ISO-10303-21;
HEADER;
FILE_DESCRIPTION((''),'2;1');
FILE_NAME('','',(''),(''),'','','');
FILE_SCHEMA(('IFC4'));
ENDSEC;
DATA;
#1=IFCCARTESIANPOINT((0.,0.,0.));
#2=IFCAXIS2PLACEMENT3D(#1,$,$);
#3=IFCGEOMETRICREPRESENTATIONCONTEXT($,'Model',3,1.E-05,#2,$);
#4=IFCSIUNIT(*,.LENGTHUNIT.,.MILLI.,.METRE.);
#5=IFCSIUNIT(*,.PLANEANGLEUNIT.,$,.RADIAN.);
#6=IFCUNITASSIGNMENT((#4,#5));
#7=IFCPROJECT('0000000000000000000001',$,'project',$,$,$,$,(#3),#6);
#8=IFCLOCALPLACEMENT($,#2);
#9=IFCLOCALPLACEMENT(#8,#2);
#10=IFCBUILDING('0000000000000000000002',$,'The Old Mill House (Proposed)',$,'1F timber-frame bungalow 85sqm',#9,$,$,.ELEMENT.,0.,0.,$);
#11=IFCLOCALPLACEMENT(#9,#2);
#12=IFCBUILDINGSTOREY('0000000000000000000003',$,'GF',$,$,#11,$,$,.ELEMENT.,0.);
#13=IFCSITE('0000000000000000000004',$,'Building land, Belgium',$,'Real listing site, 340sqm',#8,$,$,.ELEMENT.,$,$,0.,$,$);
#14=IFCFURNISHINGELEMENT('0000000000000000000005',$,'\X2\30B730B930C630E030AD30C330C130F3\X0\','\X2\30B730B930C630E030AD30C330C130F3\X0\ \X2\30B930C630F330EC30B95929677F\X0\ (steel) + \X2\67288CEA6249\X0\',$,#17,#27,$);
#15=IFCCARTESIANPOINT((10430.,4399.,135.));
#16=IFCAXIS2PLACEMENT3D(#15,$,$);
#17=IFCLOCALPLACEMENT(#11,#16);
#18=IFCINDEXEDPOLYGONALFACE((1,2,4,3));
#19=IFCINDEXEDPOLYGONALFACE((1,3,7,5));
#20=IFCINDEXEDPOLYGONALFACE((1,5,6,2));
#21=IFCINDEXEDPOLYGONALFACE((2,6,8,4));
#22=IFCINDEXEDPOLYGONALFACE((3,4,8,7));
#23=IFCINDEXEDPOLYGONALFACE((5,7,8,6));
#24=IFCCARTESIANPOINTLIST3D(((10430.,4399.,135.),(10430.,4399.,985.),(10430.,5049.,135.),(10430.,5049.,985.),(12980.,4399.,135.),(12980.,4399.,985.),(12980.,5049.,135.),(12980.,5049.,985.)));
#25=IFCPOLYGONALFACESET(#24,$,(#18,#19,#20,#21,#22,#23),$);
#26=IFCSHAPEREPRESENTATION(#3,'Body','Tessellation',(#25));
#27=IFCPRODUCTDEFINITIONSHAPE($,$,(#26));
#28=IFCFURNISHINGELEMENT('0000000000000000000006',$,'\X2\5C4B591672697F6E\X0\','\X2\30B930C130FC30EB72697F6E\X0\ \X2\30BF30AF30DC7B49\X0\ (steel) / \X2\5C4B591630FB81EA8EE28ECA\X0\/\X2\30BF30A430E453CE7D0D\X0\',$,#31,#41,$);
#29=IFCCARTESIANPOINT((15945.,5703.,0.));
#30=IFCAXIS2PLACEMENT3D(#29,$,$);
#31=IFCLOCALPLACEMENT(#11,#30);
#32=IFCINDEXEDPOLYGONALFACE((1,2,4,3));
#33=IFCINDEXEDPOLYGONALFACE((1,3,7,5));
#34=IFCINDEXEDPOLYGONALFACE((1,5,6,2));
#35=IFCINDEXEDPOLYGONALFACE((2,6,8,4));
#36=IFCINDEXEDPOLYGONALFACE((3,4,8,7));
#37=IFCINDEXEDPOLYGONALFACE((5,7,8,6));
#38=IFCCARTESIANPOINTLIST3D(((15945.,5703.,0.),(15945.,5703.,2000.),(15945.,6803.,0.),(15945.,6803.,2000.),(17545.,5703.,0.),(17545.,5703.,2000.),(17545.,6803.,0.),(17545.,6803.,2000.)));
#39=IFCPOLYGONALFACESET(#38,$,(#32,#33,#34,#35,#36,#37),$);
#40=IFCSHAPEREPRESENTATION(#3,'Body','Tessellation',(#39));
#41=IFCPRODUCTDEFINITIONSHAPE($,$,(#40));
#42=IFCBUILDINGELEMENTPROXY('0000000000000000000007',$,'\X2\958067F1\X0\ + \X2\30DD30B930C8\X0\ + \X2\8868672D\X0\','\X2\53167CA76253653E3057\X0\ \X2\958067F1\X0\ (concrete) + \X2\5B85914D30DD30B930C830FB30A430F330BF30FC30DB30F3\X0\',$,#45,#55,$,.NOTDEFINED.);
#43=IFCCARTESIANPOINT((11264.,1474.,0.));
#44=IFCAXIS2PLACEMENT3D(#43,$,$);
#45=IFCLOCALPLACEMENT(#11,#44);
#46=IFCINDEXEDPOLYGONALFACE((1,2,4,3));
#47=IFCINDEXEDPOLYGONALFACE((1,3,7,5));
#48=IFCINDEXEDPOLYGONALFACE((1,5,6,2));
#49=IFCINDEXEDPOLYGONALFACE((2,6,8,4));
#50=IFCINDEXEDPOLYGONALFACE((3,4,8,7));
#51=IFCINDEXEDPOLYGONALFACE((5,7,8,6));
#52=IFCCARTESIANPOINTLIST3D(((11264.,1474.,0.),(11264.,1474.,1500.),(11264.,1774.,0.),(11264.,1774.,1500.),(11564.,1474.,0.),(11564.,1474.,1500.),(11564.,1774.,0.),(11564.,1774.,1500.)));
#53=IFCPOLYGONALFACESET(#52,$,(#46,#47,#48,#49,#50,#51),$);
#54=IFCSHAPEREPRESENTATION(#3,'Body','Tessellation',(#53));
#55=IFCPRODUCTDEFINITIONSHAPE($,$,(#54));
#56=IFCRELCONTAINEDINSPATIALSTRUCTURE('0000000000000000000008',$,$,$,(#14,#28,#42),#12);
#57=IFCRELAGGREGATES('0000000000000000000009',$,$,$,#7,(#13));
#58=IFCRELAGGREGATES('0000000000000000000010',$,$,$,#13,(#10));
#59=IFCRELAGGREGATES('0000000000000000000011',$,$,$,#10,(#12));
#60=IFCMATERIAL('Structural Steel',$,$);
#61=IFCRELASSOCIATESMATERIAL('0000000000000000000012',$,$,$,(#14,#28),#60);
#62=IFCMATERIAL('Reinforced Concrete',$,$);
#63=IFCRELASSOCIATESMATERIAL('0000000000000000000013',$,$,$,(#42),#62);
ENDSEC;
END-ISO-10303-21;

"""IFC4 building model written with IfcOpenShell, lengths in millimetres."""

from ifc_helpers import new_model, si_unit, frame, frame_2d, origin, place, context, project, spatial, rectangle, extrude, material, element, save


model = new_model("IFC4")

# Units and contexts
model_context = context("Model", 3, precision=1e-05, world=origin())
ifc_project = project(units=[si_unit("LENGTHUNIT", "METRE", prefix="MILLI"), si_unit("PLANEANGLEUNIT", "RADIAN")], contexts=[model_context])

# Site, building, storey
site_placement = place(None, origin())
site = spatial("IfcSite", under=ifc_project, at=site_placement, Name="Building land, Belgium", ObjectType="Real listing site, 340sqm", CompositionType="ELEMENT", RefElevation=0.0)
building_placement = place(site_placement, origin())
building = spatial("IfcBuilding", under=site, at=building_placement, Name="The Old Mill House (Proposed)", ObjectType="1F timber-frame bungalow 85sqm", CompositionType="ELEMENT", ElevationOfRefHeight=0.0, ElevationOfTerrain=0.0)
storey_placement = place(building_placement, origin())
storey = spatial("IfcBuildingStorey", under=building, at=storey_placement, Name="GF", CompositionType="ELEMENT", Elevation=0.0)

# Shared definitions
ifc_material_1 = material(Name="Reinforced Concrete")

# Shared definitions
ifc_material_2 = material(Name="Structural Steel")

# Furnishing elements
furnishing_1_placement = place(storey_placement, frame((10430.0, 4399.0, 135.0)))
element("IfcFurnishingElement", 1, at=furnishing_1_placement, inside=storey, material=ifc_material_2, Name="システムキッチン", Description="システムキッチン ステンレス天板 (steel) + 木質扉", context=model_context, shape_type="SweptSolid", body=[
    extrude(rectangle(XDim=2550.0, YDim=650.0, at=frame_2d((1275.0, 325.0))), frame((10430.0, 4399.0, 135.0)), (0.0, 0.0, 1.0), 850.0),
])
furnishing_2_placement = place(storey_placement, frame((15945.0, 5703.0, 0.0)))
element("IfcFurnishingElement", 2, at=furnishing_2_placement, inside=storey, material=ifc_material_2, Name="屋外物置", Description="スチール物置 タクボ等 (steel) / 屋外・自転車/タイヤ収納", context=model_context, shape_type="SweptSolid", body=[
    extrude(rectangle(XDim=1600.0, YDim=1100.0, at=frame_2d((800.0, 550.0))), frame((15945.0, 5703.0, 0.0)), (0.0, 0.0, 1.0), 2000.0),
])

# Building element proxy
proxy_placement = place(storey_placement, frame((11264.0, 1474.0, 0.0)))
element("IfcBuildingElementProxy", 3, at=proxy_placement, inside=storey, material=ifc_material_1, Name="門柱 + ポスト + 表札", Description="化粧打放し 門柱 (concrete) + 宅配ポスト・インターホン", PredefinedType="NOTDEFINED", context=model_context, shape_type="SweptSolid", body=[
    extrude(rectangle(XDim=300.0, YDim=300.0, at=frame_2d((150.0, 150.0))), frame((11264.0, 1474.0, 0.0)), (0.0, 0.0, 1.0), 1500.0),
])

save(model, "model.ifc")
